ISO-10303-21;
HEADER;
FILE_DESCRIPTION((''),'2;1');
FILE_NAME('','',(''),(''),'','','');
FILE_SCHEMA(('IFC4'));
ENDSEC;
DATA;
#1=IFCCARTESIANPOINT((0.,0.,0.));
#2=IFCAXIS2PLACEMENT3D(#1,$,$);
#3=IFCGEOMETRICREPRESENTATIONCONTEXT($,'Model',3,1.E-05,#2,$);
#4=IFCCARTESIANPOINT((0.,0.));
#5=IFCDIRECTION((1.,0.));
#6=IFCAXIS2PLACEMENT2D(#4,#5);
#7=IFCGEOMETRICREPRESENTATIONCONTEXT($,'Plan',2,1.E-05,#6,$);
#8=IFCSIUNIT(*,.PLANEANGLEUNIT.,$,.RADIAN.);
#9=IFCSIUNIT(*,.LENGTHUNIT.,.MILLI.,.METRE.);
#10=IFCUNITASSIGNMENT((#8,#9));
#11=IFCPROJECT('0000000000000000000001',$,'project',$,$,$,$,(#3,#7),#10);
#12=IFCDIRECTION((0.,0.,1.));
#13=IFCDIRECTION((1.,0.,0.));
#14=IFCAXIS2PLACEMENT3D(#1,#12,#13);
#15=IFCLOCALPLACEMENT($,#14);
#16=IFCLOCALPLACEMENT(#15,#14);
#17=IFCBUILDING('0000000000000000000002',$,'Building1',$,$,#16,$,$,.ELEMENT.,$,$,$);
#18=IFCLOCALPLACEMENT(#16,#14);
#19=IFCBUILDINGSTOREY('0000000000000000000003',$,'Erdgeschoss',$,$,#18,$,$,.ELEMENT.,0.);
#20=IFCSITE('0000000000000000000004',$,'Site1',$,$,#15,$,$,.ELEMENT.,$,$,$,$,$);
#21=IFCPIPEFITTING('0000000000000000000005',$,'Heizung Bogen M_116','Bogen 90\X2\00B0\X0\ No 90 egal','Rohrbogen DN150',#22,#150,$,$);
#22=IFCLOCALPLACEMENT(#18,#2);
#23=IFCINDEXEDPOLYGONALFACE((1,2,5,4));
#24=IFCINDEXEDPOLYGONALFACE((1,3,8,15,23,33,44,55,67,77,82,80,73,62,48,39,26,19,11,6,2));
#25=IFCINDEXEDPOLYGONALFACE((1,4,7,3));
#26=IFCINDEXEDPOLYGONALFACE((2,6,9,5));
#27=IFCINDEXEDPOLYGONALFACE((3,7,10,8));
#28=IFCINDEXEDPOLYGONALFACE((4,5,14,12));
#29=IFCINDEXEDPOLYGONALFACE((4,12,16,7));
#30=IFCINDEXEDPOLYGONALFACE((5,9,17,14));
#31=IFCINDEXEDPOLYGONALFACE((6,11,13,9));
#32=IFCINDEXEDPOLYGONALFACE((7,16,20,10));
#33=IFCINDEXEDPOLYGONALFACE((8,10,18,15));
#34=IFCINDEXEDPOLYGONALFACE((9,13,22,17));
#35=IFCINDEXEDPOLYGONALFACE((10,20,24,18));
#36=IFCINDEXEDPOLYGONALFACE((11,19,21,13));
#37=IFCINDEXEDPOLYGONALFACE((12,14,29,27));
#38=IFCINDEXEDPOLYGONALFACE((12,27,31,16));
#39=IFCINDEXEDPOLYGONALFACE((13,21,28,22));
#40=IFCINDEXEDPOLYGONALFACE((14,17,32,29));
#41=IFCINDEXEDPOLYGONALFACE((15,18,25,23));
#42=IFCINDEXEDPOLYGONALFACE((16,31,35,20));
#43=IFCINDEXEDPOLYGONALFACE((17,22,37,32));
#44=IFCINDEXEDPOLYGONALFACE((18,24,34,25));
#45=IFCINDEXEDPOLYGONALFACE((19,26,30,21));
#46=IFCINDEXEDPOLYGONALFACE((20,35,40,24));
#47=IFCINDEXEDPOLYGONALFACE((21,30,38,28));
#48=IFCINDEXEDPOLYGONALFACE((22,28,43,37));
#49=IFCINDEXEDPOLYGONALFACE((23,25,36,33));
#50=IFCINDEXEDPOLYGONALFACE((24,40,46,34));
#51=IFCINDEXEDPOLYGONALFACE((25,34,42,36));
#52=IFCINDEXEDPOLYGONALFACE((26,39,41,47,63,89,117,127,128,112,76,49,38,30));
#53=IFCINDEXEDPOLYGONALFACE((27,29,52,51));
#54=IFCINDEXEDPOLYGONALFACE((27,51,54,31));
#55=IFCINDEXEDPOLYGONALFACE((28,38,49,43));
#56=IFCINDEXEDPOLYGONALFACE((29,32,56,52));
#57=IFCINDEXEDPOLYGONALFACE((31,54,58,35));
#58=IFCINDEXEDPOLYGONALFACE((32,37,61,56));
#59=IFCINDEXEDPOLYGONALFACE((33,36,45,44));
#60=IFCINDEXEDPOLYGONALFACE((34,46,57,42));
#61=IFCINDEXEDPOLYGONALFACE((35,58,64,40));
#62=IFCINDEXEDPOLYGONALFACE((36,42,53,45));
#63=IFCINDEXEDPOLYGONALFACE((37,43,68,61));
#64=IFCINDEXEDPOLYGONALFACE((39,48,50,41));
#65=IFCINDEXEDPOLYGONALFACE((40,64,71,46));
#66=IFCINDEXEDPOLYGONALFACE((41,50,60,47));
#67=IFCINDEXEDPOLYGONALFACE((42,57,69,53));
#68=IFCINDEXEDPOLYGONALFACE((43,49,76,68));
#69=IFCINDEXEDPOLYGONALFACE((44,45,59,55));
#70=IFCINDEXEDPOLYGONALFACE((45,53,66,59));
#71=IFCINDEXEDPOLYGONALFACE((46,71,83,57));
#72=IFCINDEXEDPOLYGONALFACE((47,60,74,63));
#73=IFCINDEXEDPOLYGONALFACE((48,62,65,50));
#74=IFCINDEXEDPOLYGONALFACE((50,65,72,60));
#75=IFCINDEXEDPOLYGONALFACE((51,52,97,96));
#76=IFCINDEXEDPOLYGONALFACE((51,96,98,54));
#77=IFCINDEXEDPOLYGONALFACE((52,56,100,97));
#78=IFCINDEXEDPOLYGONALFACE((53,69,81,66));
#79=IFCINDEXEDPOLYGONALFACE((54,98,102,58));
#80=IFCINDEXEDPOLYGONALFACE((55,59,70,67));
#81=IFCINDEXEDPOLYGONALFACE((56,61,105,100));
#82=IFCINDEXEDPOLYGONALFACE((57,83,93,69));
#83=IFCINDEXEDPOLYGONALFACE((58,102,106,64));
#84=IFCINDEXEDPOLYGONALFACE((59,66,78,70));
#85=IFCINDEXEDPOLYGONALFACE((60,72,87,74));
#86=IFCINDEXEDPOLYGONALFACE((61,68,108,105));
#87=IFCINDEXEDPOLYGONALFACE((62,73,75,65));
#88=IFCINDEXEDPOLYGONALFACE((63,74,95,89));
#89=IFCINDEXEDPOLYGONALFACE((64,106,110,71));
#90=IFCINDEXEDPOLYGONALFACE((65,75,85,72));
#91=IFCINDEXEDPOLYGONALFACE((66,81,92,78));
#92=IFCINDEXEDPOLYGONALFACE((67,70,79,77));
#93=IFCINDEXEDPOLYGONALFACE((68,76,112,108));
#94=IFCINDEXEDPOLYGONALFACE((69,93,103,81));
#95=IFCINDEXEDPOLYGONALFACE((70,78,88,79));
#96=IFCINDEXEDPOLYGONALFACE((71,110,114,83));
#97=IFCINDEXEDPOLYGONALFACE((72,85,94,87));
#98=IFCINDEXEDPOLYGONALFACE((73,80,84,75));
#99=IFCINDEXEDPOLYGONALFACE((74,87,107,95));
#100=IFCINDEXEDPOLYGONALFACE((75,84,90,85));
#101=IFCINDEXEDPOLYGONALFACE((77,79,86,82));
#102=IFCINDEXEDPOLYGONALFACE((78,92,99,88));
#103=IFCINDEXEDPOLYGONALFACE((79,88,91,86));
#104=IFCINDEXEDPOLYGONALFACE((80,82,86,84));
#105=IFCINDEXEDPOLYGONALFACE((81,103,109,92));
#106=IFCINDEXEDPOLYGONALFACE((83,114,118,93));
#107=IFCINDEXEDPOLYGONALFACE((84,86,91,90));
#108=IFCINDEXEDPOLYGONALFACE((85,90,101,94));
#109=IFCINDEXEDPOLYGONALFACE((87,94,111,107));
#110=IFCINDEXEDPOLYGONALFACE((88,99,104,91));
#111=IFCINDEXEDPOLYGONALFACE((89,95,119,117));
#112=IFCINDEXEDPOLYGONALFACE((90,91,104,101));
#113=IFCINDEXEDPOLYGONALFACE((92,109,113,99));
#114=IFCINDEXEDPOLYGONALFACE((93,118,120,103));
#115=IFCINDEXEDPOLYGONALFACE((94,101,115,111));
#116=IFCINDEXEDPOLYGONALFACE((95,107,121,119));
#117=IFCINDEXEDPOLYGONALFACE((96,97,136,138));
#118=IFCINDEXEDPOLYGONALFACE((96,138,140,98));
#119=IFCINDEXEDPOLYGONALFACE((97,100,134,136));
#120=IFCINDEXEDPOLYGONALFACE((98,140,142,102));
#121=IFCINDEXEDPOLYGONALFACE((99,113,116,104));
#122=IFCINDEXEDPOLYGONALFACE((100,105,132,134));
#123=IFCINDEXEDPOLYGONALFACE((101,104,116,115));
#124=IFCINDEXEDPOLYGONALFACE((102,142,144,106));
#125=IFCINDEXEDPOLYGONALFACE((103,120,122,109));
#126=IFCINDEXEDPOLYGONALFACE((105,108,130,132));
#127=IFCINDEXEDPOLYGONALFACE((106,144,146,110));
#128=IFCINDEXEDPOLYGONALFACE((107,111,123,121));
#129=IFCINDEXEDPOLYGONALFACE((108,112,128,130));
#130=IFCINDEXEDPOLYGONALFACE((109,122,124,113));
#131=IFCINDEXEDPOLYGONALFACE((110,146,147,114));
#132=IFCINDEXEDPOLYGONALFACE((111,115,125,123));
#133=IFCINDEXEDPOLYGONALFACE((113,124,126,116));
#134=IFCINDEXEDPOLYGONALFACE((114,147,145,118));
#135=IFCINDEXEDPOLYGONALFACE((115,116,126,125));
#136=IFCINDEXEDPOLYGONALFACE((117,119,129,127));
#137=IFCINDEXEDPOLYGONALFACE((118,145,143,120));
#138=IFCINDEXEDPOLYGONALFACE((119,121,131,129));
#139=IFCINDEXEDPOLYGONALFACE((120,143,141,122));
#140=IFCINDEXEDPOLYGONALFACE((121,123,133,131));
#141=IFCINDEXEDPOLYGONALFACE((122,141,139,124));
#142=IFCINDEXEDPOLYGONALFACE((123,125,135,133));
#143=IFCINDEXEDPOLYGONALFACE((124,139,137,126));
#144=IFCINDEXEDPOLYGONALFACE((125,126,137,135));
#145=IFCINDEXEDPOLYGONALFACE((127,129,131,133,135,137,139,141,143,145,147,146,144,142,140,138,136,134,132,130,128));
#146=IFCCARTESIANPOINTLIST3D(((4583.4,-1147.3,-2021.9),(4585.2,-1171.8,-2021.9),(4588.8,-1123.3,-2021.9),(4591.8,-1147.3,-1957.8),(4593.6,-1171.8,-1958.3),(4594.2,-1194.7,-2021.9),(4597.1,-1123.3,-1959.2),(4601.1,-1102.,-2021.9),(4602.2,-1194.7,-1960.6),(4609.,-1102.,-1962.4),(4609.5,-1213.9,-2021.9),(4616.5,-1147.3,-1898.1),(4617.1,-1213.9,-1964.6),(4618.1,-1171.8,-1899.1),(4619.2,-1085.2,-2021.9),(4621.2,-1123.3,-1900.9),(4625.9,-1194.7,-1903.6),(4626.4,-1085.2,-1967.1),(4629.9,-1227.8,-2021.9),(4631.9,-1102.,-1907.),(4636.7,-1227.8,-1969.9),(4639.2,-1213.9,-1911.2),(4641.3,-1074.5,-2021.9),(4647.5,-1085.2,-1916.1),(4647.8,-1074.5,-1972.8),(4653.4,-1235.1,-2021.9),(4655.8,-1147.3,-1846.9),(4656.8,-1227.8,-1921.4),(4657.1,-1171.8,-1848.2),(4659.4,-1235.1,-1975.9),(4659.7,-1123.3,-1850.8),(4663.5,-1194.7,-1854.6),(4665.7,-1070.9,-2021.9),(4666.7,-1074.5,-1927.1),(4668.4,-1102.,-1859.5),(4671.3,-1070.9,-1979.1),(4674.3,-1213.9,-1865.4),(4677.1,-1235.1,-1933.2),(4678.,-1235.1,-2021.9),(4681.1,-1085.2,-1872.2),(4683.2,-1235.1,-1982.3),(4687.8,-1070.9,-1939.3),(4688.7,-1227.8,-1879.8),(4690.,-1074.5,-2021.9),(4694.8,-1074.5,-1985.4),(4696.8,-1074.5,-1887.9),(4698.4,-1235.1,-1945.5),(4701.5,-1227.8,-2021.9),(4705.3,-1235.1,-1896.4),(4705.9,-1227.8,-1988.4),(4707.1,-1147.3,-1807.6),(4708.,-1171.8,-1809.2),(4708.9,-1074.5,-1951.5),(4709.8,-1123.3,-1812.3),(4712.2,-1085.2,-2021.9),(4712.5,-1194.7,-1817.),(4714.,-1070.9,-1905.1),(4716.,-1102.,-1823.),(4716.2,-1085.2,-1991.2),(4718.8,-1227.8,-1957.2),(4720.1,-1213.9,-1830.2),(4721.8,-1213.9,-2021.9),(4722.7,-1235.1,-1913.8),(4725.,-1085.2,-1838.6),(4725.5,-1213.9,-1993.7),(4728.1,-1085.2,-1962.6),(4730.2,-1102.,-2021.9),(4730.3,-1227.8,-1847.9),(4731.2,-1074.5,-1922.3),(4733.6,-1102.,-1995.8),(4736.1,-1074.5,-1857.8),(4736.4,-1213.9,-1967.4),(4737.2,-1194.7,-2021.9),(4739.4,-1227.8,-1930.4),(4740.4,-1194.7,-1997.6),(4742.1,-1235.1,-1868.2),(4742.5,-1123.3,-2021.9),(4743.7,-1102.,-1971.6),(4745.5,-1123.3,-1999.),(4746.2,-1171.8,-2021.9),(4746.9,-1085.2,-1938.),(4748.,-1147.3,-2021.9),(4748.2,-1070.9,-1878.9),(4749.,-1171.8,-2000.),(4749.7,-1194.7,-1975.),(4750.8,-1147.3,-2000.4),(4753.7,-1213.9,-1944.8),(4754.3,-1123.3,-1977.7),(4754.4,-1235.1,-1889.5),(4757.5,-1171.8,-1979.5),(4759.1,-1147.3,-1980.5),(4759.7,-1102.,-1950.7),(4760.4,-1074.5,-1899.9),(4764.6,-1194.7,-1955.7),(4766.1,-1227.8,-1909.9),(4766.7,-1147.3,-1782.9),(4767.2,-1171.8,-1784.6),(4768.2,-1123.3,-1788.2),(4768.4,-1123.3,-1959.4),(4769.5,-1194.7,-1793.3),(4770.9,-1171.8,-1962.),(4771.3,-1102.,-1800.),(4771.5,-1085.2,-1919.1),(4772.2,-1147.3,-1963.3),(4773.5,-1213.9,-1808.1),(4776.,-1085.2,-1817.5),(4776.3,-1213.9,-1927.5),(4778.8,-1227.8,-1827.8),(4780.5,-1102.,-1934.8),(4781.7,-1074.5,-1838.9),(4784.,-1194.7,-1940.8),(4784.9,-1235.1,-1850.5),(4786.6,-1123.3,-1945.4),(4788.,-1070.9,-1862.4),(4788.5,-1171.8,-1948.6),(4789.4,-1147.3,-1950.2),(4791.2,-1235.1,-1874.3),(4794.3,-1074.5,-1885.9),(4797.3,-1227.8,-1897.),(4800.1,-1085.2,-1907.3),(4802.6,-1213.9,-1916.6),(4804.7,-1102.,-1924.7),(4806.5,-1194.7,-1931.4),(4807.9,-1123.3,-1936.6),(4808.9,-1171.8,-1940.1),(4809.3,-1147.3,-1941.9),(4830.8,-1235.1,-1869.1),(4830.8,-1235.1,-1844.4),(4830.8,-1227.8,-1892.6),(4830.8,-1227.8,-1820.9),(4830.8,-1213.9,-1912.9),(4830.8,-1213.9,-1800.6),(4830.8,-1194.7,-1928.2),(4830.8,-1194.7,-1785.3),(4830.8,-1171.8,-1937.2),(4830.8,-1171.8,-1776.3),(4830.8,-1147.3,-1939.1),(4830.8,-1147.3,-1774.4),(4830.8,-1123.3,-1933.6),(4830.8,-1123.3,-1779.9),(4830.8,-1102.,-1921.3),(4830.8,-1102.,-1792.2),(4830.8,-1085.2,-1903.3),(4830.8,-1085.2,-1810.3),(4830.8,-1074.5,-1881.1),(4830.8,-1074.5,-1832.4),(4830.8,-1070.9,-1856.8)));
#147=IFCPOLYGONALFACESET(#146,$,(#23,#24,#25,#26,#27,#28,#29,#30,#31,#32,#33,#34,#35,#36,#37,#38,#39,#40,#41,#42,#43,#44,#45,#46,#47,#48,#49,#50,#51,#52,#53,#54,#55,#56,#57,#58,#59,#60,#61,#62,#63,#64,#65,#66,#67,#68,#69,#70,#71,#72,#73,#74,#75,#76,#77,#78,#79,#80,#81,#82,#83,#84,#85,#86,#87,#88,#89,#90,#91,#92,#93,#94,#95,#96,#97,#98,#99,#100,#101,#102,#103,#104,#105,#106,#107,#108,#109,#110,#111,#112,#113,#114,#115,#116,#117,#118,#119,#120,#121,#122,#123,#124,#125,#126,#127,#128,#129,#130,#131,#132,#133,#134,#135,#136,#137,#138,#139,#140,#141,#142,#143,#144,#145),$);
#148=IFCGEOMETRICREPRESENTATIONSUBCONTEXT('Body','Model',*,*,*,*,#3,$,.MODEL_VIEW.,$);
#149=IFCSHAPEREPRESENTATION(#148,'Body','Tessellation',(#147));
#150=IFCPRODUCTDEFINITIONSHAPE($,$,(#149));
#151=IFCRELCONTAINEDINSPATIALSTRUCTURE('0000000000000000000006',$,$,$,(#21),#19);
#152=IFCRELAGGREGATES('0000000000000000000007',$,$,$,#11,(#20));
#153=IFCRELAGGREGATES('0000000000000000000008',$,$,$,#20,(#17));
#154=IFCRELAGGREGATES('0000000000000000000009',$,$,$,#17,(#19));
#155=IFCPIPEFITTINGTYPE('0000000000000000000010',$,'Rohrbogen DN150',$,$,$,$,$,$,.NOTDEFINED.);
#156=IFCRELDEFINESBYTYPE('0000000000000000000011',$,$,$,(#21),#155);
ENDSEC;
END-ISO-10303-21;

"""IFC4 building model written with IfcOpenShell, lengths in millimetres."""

from ifc_helpers import new_model, entity, si_unit, frame, origin, origin_with_axes, origin_2d_with_axis, place, context, subcontext, project, spatial, source, transform, mapped, type_object, element, save


model = new_model("IFC4")

# Units and contexts
model_context = context("Model", 3, precision=1e-05, world=origin())
plan_context = context("Plan", 2, precision=1e-05, world=origin_2d_with_axis())
body_context = subcontext(model_context, "Body", "Model", "MODEL_VIEW")
ifc_project = project(units=[si_unit("PLANEANGLEUNIT", "RADIAN"), si_unit("LENGTHUNIT", "METRE", prefix="MILLI")], contexts=[model_context, plan_context])

# Site, building, storey
site_placement = place(None, origin_with_axes())
site = spatial("IfcSite", under=ifc_project, at=site_placement, Name="Site1", CompositionType="ELEMENT")
building_placement = place(site_placement, origin_with_axes())
building = spatial("IfcBuilding", under=site, at=building_placement, Name="Building1", CompositionType="ELEMENT")
storey_placement = place(building_placement, origin_with_axes())
storey = spatial("IfcBuildingStorey", under=building, at=storey_placement, Name="Erdgeschoss", CompositionType="ELEMENT", Elevation=0.0)

# Pipe fitting
pipe_fitting_type_1 = type_object("IfcPipeFittingType", Name="Rohrbogen DN150", PredefinedType="NOTDEFINED")
ifc_direction_1 = entity("IfcDirection", [-1.0, 0.0, 0.0])
shared_shape_1 = source(origin_with_axes(), body_context, "Body", "SolidModel", [
    entity("IfcRevolvedAreaSolid", entity("IfcCircleProfileDef", "AREA", None, entity("IfcAxis2Placement2D", entity("IfcCartesianPoint", [0.0, 0.0]), entity("IfcDirection", [1.0, 0.0])), 82.5), entity("IfcAxis2Placement3D", entity("IfcCartesianPoint", [123.8, 41.3, 0.0]), ifc_direction_1, entity("IfcDirection", [0.0, 0.0, -1.0])), entity("IfcAxis1Placement", entity("IfcCartesianPoint", [0.0, 165.1, 0.0]), ifc_direction_1), 1.570796),
])
pipe_fitting_1_placement = place(storey_placement, frame((4706.9, -1153.4, -1898.0), z_axis=(0.0, 0.0, 1.0), x_axis=(1.0, 0.0, 0.0)))
element("IfcPipeFitting", 1, at=pipe_fitting_1_placement, inside=storey, type_object=pipe_fitting_type_1, Name="Heizung Bogen M_116", Description="Bogen 90° No 90 egal", ObjectType="Rohrbogen DN150", context=body_context, shape_type="MappedRepresentation", body=[
    mapped(shared_shape_1, transform((0.0, 0.0, 0.0), x_axis=(1.0, 0.0, 0.0), y_axis=(0.0, 0.0, 1.0), z_axis=(0.0, -1.0, 0.0), scale=1.0)),
])

save(model, "model.ifc")
